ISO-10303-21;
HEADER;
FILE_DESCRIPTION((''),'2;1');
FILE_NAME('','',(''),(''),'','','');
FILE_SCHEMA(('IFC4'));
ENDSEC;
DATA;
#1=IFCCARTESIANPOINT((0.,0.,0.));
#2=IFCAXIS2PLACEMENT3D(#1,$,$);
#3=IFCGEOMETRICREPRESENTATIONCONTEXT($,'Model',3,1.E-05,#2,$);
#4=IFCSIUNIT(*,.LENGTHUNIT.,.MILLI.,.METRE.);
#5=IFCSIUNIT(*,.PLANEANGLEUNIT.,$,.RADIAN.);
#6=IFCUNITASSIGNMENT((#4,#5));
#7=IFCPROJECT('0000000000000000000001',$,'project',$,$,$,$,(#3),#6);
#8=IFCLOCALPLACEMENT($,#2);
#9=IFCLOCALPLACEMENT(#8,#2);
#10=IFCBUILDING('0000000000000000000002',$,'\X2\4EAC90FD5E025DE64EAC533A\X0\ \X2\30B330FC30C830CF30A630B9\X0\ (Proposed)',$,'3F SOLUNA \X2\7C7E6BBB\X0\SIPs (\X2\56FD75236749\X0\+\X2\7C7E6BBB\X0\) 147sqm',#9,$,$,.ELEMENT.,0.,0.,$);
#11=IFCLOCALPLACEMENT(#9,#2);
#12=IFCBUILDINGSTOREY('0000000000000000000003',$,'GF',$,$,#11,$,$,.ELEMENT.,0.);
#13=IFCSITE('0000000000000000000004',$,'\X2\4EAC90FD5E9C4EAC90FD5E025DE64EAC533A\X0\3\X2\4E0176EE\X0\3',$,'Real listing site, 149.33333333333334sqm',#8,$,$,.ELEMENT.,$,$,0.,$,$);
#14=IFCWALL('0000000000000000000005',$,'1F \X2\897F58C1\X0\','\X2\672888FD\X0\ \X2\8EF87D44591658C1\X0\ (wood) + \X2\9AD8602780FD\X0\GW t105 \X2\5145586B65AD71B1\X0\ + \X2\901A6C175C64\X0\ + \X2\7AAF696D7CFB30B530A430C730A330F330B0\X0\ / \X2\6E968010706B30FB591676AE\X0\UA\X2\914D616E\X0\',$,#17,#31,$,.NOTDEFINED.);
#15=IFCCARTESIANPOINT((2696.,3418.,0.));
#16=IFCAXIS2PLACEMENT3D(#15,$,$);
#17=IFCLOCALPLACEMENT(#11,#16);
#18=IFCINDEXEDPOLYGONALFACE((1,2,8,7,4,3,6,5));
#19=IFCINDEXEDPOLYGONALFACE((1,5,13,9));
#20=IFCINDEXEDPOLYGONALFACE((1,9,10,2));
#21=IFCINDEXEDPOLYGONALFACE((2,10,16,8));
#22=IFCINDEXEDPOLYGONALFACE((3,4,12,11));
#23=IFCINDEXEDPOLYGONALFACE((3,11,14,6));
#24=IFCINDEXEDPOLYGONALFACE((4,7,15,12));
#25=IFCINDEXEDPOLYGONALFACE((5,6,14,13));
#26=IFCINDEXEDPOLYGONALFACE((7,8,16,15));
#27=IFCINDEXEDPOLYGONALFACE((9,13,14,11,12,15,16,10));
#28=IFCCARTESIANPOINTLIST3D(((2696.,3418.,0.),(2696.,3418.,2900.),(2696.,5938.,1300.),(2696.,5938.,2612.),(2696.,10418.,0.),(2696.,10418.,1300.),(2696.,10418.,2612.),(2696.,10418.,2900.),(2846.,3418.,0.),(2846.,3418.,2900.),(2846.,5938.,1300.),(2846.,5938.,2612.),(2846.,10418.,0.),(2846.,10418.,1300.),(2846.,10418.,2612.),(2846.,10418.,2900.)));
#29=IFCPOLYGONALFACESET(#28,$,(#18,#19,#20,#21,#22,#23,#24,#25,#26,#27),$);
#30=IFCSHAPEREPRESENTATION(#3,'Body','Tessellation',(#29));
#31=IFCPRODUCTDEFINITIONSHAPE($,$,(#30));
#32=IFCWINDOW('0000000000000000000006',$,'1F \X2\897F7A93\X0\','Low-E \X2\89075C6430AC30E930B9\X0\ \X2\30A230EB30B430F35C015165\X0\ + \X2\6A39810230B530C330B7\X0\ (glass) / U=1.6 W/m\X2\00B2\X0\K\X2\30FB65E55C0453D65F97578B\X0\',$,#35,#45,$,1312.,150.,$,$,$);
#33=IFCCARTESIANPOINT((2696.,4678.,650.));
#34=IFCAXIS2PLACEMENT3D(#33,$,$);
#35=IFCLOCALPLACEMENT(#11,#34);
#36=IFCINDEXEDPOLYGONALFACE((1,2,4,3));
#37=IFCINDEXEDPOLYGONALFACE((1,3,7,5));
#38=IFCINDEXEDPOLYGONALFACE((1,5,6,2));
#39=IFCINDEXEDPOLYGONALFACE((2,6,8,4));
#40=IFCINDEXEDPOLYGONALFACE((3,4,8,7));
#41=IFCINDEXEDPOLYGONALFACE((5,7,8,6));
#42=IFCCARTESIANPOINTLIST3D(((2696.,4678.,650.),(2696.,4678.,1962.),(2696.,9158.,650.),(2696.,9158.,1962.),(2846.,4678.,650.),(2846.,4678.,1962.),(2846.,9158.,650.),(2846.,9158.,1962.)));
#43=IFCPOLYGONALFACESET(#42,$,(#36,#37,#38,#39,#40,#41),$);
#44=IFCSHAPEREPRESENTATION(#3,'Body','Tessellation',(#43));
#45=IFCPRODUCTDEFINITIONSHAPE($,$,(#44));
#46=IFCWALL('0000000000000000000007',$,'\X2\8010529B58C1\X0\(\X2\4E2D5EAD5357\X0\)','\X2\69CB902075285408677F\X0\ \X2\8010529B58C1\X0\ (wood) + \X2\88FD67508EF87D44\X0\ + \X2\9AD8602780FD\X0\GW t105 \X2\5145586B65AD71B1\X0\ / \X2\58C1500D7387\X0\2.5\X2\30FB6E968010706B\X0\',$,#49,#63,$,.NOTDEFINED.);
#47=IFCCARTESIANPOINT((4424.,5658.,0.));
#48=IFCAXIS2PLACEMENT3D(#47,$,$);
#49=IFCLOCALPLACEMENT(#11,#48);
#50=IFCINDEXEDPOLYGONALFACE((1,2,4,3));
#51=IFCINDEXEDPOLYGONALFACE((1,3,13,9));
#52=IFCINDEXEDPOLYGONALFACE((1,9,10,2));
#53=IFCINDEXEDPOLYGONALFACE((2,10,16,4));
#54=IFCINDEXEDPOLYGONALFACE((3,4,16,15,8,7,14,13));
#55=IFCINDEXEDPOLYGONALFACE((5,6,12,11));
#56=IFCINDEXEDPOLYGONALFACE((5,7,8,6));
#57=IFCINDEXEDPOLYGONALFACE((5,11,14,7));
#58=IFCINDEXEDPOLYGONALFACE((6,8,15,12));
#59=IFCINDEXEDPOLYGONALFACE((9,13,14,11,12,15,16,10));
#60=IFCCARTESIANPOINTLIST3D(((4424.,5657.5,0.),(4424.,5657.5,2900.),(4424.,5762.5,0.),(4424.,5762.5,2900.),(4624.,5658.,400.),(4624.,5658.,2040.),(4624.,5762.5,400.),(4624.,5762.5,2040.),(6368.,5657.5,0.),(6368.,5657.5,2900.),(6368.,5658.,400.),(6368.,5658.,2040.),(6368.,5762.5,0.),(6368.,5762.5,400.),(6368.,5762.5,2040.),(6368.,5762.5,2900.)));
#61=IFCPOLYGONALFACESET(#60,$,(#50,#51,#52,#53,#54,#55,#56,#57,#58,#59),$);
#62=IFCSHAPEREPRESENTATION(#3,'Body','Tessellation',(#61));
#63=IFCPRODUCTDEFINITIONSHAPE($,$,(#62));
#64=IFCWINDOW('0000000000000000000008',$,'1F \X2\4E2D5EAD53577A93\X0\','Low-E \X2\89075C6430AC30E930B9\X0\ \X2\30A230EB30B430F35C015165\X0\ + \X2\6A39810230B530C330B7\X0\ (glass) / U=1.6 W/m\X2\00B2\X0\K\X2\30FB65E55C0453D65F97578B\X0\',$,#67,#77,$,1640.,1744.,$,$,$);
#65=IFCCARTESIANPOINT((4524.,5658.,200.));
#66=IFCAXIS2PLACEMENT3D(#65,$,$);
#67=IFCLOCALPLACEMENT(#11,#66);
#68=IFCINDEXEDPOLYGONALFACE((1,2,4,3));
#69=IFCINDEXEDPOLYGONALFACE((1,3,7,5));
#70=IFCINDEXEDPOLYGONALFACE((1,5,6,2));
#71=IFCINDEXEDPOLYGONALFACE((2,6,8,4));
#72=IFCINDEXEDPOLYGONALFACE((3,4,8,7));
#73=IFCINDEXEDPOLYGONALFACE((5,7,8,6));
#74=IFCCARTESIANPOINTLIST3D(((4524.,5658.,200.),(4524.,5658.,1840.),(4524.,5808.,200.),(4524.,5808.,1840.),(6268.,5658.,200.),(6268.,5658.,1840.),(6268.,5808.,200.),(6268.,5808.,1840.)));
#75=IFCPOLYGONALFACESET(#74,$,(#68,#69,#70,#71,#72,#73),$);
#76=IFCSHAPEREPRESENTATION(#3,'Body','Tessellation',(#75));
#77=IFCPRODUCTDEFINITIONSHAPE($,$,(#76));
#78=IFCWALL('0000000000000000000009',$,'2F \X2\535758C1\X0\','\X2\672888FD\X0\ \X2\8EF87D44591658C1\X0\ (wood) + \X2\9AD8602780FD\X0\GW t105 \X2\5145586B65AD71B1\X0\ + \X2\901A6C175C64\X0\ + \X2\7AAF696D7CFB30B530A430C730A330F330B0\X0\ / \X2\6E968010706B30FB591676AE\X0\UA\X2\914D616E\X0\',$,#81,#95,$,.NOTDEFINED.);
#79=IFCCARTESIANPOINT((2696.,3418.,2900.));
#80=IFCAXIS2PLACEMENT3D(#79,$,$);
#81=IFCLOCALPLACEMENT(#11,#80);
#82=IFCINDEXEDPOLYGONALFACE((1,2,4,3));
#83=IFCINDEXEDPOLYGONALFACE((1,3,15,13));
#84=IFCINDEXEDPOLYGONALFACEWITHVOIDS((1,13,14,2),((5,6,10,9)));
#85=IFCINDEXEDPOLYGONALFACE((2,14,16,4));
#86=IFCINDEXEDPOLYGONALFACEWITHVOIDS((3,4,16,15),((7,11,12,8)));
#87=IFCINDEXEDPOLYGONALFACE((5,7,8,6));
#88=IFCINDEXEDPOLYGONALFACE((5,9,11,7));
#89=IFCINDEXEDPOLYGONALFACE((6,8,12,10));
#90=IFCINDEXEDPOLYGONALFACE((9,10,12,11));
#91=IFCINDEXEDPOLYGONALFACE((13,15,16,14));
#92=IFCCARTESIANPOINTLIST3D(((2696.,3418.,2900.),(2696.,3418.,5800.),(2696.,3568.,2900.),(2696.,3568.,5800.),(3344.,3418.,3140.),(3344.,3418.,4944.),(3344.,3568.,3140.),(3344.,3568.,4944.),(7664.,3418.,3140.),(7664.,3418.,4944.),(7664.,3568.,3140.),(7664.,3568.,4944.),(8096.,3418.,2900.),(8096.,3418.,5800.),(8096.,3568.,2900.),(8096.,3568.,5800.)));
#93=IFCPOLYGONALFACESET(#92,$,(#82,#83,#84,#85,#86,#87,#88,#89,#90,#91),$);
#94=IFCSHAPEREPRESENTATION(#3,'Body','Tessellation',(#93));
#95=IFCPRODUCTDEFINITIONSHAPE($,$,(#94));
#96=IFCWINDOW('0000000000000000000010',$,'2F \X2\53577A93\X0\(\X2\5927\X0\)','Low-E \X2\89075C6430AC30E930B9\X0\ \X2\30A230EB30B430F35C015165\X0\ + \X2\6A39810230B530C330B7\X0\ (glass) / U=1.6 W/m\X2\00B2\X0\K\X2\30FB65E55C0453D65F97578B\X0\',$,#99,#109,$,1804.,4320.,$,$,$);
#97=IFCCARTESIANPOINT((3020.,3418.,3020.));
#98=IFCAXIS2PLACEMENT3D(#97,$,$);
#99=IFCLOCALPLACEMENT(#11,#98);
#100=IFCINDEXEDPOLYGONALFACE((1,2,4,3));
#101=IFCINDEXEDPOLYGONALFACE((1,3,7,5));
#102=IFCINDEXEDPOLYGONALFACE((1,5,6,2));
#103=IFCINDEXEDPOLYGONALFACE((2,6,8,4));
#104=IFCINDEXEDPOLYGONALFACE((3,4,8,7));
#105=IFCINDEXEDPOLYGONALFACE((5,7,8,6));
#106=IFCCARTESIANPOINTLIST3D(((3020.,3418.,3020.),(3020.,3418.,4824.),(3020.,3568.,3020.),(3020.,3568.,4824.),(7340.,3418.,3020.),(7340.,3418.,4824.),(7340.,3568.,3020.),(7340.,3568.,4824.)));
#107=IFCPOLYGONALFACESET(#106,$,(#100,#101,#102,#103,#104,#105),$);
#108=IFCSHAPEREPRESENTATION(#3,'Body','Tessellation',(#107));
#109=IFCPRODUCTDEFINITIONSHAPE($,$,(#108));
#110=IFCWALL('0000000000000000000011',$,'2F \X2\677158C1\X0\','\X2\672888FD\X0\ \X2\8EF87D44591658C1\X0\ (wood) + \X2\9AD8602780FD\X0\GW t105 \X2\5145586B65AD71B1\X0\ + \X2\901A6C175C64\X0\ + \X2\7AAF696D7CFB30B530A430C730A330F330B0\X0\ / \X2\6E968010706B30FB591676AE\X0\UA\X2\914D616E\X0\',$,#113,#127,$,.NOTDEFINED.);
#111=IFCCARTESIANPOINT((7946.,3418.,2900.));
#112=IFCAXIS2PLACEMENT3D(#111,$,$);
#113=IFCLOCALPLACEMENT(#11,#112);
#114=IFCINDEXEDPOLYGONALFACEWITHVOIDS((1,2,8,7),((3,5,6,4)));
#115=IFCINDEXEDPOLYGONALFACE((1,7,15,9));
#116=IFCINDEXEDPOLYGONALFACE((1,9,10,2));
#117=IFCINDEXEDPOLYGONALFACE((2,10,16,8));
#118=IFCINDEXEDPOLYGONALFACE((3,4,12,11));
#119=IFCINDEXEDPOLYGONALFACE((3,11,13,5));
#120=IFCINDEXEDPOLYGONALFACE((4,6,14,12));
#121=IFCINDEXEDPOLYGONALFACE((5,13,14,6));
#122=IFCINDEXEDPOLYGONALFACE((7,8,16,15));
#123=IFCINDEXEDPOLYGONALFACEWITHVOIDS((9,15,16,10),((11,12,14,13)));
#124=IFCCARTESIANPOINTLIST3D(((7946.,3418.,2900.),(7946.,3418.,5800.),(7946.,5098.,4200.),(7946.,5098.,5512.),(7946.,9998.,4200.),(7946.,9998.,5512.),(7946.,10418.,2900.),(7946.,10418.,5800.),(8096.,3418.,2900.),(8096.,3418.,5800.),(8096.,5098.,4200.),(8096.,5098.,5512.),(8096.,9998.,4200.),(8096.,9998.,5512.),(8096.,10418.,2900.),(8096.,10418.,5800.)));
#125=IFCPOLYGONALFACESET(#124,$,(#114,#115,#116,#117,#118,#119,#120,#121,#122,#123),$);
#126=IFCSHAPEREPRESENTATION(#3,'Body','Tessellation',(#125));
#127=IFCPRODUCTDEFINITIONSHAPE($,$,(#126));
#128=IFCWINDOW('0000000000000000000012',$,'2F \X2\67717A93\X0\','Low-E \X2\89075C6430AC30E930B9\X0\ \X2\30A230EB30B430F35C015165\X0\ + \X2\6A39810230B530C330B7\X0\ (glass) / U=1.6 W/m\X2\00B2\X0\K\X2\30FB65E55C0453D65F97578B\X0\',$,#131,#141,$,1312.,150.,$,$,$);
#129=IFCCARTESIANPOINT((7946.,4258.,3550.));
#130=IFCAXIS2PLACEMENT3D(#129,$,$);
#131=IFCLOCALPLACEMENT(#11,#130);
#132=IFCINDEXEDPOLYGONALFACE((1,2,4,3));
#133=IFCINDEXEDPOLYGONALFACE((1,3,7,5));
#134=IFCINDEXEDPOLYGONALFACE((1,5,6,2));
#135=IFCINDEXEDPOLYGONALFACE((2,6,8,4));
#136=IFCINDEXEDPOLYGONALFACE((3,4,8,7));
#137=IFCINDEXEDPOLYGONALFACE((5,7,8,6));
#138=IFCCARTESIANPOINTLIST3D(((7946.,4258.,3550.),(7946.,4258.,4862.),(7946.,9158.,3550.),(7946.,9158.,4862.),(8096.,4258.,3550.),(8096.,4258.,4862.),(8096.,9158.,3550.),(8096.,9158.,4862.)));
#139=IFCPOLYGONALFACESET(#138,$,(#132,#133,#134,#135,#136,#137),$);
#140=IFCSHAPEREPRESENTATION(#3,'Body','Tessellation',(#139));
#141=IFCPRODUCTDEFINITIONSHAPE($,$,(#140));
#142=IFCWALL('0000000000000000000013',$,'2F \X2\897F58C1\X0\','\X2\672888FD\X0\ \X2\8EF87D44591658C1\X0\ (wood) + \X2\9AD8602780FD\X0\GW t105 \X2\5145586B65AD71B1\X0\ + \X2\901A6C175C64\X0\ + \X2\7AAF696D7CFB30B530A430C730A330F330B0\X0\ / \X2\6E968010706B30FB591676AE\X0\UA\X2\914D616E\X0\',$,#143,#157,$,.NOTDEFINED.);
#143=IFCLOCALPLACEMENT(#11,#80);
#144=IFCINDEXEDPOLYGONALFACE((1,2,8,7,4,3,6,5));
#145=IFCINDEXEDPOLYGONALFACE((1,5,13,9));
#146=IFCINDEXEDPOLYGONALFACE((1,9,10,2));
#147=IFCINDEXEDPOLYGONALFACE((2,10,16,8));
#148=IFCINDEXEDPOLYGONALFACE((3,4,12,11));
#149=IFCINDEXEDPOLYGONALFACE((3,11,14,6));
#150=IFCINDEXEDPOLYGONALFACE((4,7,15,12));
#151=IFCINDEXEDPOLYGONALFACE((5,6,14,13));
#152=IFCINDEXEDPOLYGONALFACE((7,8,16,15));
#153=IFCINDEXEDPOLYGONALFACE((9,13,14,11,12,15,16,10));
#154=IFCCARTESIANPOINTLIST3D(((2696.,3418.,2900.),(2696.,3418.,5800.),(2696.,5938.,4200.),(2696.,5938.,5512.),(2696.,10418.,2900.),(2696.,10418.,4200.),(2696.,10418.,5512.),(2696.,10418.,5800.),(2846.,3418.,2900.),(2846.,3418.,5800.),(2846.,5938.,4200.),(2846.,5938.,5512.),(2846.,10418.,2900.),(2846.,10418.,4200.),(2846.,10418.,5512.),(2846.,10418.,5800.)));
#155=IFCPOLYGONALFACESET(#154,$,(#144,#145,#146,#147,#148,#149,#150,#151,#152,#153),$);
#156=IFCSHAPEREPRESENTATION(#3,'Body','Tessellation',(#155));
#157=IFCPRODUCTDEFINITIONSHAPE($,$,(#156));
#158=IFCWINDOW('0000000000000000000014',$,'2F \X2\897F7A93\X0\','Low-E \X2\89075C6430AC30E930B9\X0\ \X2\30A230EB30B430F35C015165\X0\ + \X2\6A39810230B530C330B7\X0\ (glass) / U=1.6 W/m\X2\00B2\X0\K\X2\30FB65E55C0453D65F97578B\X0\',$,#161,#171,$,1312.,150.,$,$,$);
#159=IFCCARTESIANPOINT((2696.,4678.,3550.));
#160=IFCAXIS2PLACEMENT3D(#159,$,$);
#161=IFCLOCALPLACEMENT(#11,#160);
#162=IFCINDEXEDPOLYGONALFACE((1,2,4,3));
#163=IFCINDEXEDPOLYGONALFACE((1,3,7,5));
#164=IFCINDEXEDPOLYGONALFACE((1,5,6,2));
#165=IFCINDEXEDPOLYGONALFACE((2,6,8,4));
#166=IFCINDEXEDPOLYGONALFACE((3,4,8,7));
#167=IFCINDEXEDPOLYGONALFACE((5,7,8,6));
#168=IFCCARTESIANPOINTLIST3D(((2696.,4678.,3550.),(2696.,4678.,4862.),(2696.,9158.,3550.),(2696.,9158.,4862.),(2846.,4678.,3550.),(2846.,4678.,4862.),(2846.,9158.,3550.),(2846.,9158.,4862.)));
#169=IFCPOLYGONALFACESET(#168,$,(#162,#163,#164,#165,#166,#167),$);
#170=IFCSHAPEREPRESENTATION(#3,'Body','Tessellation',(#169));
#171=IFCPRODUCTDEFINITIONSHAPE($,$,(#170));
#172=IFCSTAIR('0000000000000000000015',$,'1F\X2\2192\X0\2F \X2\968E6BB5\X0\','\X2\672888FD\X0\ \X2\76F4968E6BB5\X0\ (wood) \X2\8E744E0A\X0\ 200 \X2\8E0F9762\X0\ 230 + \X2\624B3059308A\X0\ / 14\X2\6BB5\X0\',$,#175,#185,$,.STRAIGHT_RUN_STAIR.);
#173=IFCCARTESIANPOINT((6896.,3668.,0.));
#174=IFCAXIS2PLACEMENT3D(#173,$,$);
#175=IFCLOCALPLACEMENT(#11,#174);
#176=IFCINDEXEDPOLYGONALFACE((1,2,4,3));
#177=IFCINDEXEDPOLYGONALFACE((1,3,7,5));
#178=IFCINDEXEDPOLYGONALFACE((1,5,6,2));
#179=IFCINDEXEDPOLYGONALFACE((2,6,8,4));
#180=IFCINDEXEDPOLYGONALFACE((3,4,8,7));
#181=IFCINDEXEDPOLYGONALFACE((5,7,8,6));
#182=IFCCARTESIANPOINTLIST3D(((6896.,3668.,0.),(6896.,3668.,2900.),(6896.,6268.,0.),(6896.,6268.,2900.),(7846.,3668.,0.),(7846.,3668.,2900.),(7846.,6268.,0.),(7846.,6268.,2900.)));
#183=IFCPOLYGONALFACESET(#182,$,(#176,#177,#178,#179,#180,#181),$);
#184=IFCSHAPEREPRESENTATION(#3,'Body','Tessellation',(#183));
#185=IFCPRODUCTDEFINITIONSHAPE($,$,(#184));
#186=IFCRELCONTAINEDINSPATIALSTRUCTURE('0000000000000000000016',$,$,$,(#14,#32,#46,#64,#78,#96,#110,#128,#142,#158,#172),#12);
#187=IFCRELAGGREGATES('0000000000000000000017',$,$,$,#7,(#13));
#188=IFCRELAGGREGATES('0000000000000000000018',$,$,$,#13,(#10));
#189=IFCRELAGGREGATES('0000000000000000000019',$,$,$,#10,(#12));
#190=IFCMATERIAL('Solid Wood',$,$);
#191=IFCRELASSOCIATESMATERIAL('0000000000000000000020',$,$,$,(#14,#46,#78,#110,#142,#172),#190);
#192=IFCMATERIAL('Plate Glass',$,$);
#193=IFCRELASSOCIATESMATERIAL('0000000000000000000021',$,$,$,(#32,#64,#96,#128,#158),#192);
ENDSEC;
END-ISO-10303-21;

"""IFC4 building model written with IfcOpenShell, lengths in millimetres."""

from ifc_helpers import new_model, si_unit, frame, frame_2d, origin, place, context, project, spatial, rectangle, extrude, material, element, fill, save


model = new_model("IFC4")

# Units and contexts
model_context = context("Model", 3, precision=1e-05, world=origin())
ifc_project = project(units=[si_unit("LENGTHUNIT", "METRE", prefix="MILLI"), si_unit("PLANEANGLEUNIT", "RADIAN")], contexts=[model_context])

# Site, building, storey
site_placement = place(None, origin())
site = spatial("IfcSite", under=ifc_project, at=site_placement, Name="京都府京都市左京区3丁目3", ObjectType="Real listing site, 149.33333333333334sqm", CompositionType="ELEMENT", RefElevation=0.0)
building_placement = place(site_placement, origin())
building = spatial("IfcBuilding", under=site, at=building_placement, Name="京都市左京区 コートハウス (Proposed)", ObjectType="3F SOLUNA 籾殻SIPs (国産杉+籾殻) 147sqm", CompositionType="ELEMENT", ElevationOfRefHeight=0.0, ElevationOfTerrain=0.0)
storey_placement = place(building_placement, origin())
storey = spatial("IfcBuildingStorey", under=building, at=storey_placement, Name="GF", CompositionType="ELEMENT", Elevation=0.0)

# Shared definitions
ifc_material_1 = material(Name="Solid Wood")

# Shared definitions
ifc_material_2 = material(Name="Plate Glass")

# Walls, openings, windows
wall_1_placement = place(storey_placement, frame((2696.0, 3418.0, 0.0)))
wall_1 = element("IfcWall", 1, at=wall_1_placement, inside=storey, material=ifc_material_1, Name="1F 西壁", Description="木製 軸組外壁 (wood) + 高性能GW t105 充填断熱 + 通気層 + 窯業系サイディング / 準耐火・外皮UA配慮", PredefinedType="NOTDEFINED", context=model_context, shape_type="SweptSolid", body=[
    extrude(rectangle(XDim=150.0, YDim=7000.0, at=frame_2d((75.0, 3500.0))), frame((2696.0, 3418.0, 0.0)), (0.0, 0.0, 1.0), 2900.0),
])
opening_1_placement = place(storey_placement, frame((2696.0, 4678.0, 650.0)))
opening_1 = element("IfcOpeningElement", 2, at=opening_1_placement, cuts=wall_1, PredefinedType="NOTDEFINED", context=model_context, shape_type="SweptSolid", body=[
    extrude(rectangle(XDim=150.0, YDim=4480.0, at=frame_2d((75.0, 2240.0))), frame((2696.0, 4678.0, 650.0)), (0.0, 0.0, 1.0), 1312.0),
])
window_1_placement = place(storey_placement, frame((2696.0, 4678.0, 650.0)))
window_1 = element("IfcWindow", 3, at=window_1_placement, inside=storey, material=ifc_material_2, Name="1F 西窓", Description="Low-E 複層ガラス アルゴン封入 + 樹脂サッシ (glass) / U=1.6 W/m²K・日射取得型", OverallHeight=1312.0, OverallWidth=150.0, context=model_context, shape_type="SweptSolid", body=[
    extrude(rectangle(XDim=150.0, YDim=4480.0, at=frame_2d((75.0, 2240.0))), frame((2696.0, 4678.0, 650.0)), (0.0, 0.0, 1.0), 1312.0),
])
fill(opening_1, window_1)
wall_2_placement = place(storey_placement, frame((4424.0, 5658.0, 0.0)))
wall_2 = element("IfcWall", 4, at=wall_2_placement, inside=storey, material=ifc_material_1, Name="耐力壁(中庭南)", Description="構造用合板 耐力壁 (wood) + 製材軸組 + 高性能GW t105 充填断熱 / 壁倍率2.5・準耐火", PredefinedType="NOTDEFINED", context=model_context, shape_type="SweptSolid", body=[
    extrude(rectangle(XDim=1944.0, YDim=105.0, at=frame_2d((972.0, 52.0))), frame((4424.0, 5658.0, 0.0)), (0.0, 0.0, 1.0), 2900.0),
])
opening_2_placement = place(storey_placement, frame((4524.0, 5658.0, 200.0)))
opening_2 = element("IfcOpeningElement", 5, at=opening_2_placement, cuts=wall_2, PredefinedType="NOTDEFINED", context=model_context, shape_type="SweptSolid", body=[
    extrude(rectangle(XDim=1744.0, YDim=150.0, at=frame_2d((872.0, 75.0))), frame((4524.0, 5658.0, 200.0)), (0.0, 0.0, 1.0), 1640.0),
])
window_2_placement = place(storey_placement, frame((4524.0, 5658.0, 200.0)))
window_2 = element("IfcWindow", 6, at=window_2_placement, inside=storey, material=ifc_material_2, Name="1F 中庭南窓", Description="Low-E 複層ガラス アルゴン封入 + 樹脂サッシ (glass) / U=1.6 W/m²K・日射取得型", OverallHeight=1640.0, OverallWidth=1744.0, context=model_context, shape_type="SweptSolid", body=[
    extrude(rectangle(XDim=1744.0, YDim=150.0, at=frame_2d((872.0, 75.0))), frame((4524.0, 5658.0, 200.0)), (0.0, 0.0, 1.0), 1640.0),
])
fill(opening_2, window_2)
wall_3_placement = place(storey_placement, frame((2696.0, 3418.0, 2900.0)))
wall_3 = element("IfcWall", 7, at=wall_3_placement, inside=storey, material=ifc_material_1, Name="2F 南壁", Description="木製 軸組外壁 (wood) + 高性能GW t105 充填断熱 + 通気層 + 窯業系サイディング / 準耐火・外皮UA配慮", PredefinedType="NOTDEFINED", context=model_context, shape_type="SweptSolid", body=[
    extrude(rectangle(XDim=5400.0, YDim=150.0, at=frame_2d((2700.0, 75.0))), frame((2696.0, 3418.0, 2900.0)), (0.0, 0.0, 1.0), 2900.0),
])
opening_3_placement = place(storey_placement, frame((3020.0, 3418.0, 3020.0)))
opening_3 = element("IfcOpeningElement", 8, at=opening_3_placement, cuts=wall_3, PredefinedType="NOTDEFINED", context=model_context, shape_type="SweptSolid", body=[
    extrude(rectangle(XDim=4320.0, YDim=150.0, at=frame_2d((2160.0, 75.0))), frame((3020.0, 3418.0, 3020.0)), (0.0, 0.0, 1.0), 1804.0),
])
window_3_placement = place(storey_placement, frame((3020.0, 3418.0, 3020.0)))
window_3 = element("IfcWindow", 9, at=window_3_placement, inside=storey, material=ifc_material_2, Name="2F 南窓(大)", Description="Low-E 複層ガラス アルゴン封入 + 樹脂サッシ (glass) / U=1.6 W/m²K・日射取得型", OverallHeight=1804.0, OverallWidth=4320.0, context=model_context, shape_type="SweptSolid", body=[
    extrude(rectangle(XDim=4320.0, YDim=150.0, at=frame_2d((2160.0, 75.0))), frame((3020.0, 3418.0, 3020.0)), (0.0, 0.0, 1.0), 1804.0),
])
fill(opening_3, window_3)
wall_4_placement = place(storey_placement, frame((7946.0, 3418.0, 2900.0)))
wall_4 = element("IfcWall", 10, at=wall_4_placement, inside=storey, material=ifc_material_1, Name="2F 東壁", Description="木製 軸組外壁 (wood) + 高性能GW t105 充填断熱 + 通気層 + 窯業系サイディング / 準耐火・外皮UA配慮", PredefinedType="NOTDEFINED", context=model_context, shape_type="SweptSolid", body=[
    extrude(rectangle(XDim=150.0, YDim=7000.0, at=frame_2d((75.0, 3500.0))), frame((7946.0, 3418.0, 2900.0)), (0.0, 0.0, 1.0), 2900.0),
])
opening_4_placement = place(storey_placement, frame((7946.0, 4258.0, 3550.0)))
opening_4 = element("IfcOpeningElement", 11, at=opening_4_placement, cuts=wall_4, PredefinedType="NOTDEFINED", context=model_context, shape_type="SweptSolid", body=[
    extrude(rectangle(XDim=150.0, YDim=4900.0, at=frame_2d((75.0, 2450.0))), frame((7946.0, 4258.0, 3550.0)), (0.0, 0.0, 1.0), 1312.0),
])
window_4_placement = place(storey_placement, frame((7946.0, 4258.0, 3550.0)))
window_4 = element("IfcWindow", 12, at=window_4_placement, inside=storey, material=ifc_material_2, Name="2F 東窓", Description="Low-E 複層ガラス アルゴン封入 + 樹脂サッシ (glass) / U=1.6 W/m²K・日射取得型", OverallHeight=1312.0, OverallWidth=150.0, context=model_context, shape_type="SweptSolid", body=[
    extrude(rectangle(XDim=150.0, YDim=4900.0, at=frame_2d((75.0, 2450.0))), frame((7946.0, 4258.0, 3550.0)), (0.0, 0.0, 1.0), 1312.0),
])
fill(opening_4, window_4)
wall_5_placement = place(storey_placement, frame((2696.0, 3418.0, 2900.0)))
wall_5 = element("IfcWall", 13, at=wall_5_placement, inside=storey, material=ifc_material_1, Name="2F 西壁", Description="木製 軸組外壁 (wood) + 高性能GW t105 充填断熱 + 通気層 + 窯業系サイディング / 準耐火・外皮UA配慮", PredefinedType="NOTDEFINED", context=model_context, shape_type="SweptSolid", body=[
    extrude(rectangle(XDim=150.0, YDim=7000.0, at=frame_2d((75.0, 3500.0))), frame((2696.0, 3418.0, 2900.0)), (0.0, 0.0, 1.0), 2900.0),
])
opening_5_placement = place(storey_placement, frame((2696.0, 4678.0, 3550.0)))
opening_5 = element("IfcOpeningElement", 14, at=opening_5_placement, cuts=wall_5, PredefinedType="NOTDEFINED", context=model_context, shape_type="SweptSolid", body=[
    extrude(rectangle(XDim=150.0, YDim=4480.0, at=frame_2d((75.0, 2240.0))), frame((2696.0, 4678.0, 3550.0)), (0.0, 0.0, 1.0), 1312.0),
])
window_5_placement = place(storey_placement, frame((2696.0, 4678.0, 3550.0)))
window_5 = element("IfcWindow", 15, at=window_5_placement, inside=storey, material=ifc_material_2, Name="2F 西窓", Description="Low-E 複層ガラス アルゴン封入 + 樹脂サッシ (glass) / U=1.6 W/m²K・日射取得型", OverallHeight=1312.0, OverallWidth=150.0, context=model_context, shape_type="SweptSolid", body=[
    extrude(rectangle(XDim=150.0, YDim=4480.0, at=frame_2d((75.0, 2240.0))), frame((2696.0, 4678.0, 3550.0)), (0.0, 0.0, 1.0), 1312.0),
])
fill(opening_5, window_5)

# Stair
stair_1_placement = place(storey_placement, frame((6896.0, 3668.0, 0.0)))
element("IfcStair", 16, at=stair_1_placement, inside=storey, material=ifc_material_1, Name="1F→2F 階段", Description="木製 直階段 (wood) 蹴上 200 踏面 230 + 手すり / 14段", PredefinedType="STRAIGHT_RUN_STAIR", context=model_context, shape_type="SweptSolid", body=[
    extrude(rectangle(XDim=950.0, YDim=2600.0, at=frame_2d((475.0, 1300.0))), frame((6896.0, 3668.0, 0.0)), (0.0, 0.0, 1.0), 2900.0),
])

save(model, "model.ifc")
